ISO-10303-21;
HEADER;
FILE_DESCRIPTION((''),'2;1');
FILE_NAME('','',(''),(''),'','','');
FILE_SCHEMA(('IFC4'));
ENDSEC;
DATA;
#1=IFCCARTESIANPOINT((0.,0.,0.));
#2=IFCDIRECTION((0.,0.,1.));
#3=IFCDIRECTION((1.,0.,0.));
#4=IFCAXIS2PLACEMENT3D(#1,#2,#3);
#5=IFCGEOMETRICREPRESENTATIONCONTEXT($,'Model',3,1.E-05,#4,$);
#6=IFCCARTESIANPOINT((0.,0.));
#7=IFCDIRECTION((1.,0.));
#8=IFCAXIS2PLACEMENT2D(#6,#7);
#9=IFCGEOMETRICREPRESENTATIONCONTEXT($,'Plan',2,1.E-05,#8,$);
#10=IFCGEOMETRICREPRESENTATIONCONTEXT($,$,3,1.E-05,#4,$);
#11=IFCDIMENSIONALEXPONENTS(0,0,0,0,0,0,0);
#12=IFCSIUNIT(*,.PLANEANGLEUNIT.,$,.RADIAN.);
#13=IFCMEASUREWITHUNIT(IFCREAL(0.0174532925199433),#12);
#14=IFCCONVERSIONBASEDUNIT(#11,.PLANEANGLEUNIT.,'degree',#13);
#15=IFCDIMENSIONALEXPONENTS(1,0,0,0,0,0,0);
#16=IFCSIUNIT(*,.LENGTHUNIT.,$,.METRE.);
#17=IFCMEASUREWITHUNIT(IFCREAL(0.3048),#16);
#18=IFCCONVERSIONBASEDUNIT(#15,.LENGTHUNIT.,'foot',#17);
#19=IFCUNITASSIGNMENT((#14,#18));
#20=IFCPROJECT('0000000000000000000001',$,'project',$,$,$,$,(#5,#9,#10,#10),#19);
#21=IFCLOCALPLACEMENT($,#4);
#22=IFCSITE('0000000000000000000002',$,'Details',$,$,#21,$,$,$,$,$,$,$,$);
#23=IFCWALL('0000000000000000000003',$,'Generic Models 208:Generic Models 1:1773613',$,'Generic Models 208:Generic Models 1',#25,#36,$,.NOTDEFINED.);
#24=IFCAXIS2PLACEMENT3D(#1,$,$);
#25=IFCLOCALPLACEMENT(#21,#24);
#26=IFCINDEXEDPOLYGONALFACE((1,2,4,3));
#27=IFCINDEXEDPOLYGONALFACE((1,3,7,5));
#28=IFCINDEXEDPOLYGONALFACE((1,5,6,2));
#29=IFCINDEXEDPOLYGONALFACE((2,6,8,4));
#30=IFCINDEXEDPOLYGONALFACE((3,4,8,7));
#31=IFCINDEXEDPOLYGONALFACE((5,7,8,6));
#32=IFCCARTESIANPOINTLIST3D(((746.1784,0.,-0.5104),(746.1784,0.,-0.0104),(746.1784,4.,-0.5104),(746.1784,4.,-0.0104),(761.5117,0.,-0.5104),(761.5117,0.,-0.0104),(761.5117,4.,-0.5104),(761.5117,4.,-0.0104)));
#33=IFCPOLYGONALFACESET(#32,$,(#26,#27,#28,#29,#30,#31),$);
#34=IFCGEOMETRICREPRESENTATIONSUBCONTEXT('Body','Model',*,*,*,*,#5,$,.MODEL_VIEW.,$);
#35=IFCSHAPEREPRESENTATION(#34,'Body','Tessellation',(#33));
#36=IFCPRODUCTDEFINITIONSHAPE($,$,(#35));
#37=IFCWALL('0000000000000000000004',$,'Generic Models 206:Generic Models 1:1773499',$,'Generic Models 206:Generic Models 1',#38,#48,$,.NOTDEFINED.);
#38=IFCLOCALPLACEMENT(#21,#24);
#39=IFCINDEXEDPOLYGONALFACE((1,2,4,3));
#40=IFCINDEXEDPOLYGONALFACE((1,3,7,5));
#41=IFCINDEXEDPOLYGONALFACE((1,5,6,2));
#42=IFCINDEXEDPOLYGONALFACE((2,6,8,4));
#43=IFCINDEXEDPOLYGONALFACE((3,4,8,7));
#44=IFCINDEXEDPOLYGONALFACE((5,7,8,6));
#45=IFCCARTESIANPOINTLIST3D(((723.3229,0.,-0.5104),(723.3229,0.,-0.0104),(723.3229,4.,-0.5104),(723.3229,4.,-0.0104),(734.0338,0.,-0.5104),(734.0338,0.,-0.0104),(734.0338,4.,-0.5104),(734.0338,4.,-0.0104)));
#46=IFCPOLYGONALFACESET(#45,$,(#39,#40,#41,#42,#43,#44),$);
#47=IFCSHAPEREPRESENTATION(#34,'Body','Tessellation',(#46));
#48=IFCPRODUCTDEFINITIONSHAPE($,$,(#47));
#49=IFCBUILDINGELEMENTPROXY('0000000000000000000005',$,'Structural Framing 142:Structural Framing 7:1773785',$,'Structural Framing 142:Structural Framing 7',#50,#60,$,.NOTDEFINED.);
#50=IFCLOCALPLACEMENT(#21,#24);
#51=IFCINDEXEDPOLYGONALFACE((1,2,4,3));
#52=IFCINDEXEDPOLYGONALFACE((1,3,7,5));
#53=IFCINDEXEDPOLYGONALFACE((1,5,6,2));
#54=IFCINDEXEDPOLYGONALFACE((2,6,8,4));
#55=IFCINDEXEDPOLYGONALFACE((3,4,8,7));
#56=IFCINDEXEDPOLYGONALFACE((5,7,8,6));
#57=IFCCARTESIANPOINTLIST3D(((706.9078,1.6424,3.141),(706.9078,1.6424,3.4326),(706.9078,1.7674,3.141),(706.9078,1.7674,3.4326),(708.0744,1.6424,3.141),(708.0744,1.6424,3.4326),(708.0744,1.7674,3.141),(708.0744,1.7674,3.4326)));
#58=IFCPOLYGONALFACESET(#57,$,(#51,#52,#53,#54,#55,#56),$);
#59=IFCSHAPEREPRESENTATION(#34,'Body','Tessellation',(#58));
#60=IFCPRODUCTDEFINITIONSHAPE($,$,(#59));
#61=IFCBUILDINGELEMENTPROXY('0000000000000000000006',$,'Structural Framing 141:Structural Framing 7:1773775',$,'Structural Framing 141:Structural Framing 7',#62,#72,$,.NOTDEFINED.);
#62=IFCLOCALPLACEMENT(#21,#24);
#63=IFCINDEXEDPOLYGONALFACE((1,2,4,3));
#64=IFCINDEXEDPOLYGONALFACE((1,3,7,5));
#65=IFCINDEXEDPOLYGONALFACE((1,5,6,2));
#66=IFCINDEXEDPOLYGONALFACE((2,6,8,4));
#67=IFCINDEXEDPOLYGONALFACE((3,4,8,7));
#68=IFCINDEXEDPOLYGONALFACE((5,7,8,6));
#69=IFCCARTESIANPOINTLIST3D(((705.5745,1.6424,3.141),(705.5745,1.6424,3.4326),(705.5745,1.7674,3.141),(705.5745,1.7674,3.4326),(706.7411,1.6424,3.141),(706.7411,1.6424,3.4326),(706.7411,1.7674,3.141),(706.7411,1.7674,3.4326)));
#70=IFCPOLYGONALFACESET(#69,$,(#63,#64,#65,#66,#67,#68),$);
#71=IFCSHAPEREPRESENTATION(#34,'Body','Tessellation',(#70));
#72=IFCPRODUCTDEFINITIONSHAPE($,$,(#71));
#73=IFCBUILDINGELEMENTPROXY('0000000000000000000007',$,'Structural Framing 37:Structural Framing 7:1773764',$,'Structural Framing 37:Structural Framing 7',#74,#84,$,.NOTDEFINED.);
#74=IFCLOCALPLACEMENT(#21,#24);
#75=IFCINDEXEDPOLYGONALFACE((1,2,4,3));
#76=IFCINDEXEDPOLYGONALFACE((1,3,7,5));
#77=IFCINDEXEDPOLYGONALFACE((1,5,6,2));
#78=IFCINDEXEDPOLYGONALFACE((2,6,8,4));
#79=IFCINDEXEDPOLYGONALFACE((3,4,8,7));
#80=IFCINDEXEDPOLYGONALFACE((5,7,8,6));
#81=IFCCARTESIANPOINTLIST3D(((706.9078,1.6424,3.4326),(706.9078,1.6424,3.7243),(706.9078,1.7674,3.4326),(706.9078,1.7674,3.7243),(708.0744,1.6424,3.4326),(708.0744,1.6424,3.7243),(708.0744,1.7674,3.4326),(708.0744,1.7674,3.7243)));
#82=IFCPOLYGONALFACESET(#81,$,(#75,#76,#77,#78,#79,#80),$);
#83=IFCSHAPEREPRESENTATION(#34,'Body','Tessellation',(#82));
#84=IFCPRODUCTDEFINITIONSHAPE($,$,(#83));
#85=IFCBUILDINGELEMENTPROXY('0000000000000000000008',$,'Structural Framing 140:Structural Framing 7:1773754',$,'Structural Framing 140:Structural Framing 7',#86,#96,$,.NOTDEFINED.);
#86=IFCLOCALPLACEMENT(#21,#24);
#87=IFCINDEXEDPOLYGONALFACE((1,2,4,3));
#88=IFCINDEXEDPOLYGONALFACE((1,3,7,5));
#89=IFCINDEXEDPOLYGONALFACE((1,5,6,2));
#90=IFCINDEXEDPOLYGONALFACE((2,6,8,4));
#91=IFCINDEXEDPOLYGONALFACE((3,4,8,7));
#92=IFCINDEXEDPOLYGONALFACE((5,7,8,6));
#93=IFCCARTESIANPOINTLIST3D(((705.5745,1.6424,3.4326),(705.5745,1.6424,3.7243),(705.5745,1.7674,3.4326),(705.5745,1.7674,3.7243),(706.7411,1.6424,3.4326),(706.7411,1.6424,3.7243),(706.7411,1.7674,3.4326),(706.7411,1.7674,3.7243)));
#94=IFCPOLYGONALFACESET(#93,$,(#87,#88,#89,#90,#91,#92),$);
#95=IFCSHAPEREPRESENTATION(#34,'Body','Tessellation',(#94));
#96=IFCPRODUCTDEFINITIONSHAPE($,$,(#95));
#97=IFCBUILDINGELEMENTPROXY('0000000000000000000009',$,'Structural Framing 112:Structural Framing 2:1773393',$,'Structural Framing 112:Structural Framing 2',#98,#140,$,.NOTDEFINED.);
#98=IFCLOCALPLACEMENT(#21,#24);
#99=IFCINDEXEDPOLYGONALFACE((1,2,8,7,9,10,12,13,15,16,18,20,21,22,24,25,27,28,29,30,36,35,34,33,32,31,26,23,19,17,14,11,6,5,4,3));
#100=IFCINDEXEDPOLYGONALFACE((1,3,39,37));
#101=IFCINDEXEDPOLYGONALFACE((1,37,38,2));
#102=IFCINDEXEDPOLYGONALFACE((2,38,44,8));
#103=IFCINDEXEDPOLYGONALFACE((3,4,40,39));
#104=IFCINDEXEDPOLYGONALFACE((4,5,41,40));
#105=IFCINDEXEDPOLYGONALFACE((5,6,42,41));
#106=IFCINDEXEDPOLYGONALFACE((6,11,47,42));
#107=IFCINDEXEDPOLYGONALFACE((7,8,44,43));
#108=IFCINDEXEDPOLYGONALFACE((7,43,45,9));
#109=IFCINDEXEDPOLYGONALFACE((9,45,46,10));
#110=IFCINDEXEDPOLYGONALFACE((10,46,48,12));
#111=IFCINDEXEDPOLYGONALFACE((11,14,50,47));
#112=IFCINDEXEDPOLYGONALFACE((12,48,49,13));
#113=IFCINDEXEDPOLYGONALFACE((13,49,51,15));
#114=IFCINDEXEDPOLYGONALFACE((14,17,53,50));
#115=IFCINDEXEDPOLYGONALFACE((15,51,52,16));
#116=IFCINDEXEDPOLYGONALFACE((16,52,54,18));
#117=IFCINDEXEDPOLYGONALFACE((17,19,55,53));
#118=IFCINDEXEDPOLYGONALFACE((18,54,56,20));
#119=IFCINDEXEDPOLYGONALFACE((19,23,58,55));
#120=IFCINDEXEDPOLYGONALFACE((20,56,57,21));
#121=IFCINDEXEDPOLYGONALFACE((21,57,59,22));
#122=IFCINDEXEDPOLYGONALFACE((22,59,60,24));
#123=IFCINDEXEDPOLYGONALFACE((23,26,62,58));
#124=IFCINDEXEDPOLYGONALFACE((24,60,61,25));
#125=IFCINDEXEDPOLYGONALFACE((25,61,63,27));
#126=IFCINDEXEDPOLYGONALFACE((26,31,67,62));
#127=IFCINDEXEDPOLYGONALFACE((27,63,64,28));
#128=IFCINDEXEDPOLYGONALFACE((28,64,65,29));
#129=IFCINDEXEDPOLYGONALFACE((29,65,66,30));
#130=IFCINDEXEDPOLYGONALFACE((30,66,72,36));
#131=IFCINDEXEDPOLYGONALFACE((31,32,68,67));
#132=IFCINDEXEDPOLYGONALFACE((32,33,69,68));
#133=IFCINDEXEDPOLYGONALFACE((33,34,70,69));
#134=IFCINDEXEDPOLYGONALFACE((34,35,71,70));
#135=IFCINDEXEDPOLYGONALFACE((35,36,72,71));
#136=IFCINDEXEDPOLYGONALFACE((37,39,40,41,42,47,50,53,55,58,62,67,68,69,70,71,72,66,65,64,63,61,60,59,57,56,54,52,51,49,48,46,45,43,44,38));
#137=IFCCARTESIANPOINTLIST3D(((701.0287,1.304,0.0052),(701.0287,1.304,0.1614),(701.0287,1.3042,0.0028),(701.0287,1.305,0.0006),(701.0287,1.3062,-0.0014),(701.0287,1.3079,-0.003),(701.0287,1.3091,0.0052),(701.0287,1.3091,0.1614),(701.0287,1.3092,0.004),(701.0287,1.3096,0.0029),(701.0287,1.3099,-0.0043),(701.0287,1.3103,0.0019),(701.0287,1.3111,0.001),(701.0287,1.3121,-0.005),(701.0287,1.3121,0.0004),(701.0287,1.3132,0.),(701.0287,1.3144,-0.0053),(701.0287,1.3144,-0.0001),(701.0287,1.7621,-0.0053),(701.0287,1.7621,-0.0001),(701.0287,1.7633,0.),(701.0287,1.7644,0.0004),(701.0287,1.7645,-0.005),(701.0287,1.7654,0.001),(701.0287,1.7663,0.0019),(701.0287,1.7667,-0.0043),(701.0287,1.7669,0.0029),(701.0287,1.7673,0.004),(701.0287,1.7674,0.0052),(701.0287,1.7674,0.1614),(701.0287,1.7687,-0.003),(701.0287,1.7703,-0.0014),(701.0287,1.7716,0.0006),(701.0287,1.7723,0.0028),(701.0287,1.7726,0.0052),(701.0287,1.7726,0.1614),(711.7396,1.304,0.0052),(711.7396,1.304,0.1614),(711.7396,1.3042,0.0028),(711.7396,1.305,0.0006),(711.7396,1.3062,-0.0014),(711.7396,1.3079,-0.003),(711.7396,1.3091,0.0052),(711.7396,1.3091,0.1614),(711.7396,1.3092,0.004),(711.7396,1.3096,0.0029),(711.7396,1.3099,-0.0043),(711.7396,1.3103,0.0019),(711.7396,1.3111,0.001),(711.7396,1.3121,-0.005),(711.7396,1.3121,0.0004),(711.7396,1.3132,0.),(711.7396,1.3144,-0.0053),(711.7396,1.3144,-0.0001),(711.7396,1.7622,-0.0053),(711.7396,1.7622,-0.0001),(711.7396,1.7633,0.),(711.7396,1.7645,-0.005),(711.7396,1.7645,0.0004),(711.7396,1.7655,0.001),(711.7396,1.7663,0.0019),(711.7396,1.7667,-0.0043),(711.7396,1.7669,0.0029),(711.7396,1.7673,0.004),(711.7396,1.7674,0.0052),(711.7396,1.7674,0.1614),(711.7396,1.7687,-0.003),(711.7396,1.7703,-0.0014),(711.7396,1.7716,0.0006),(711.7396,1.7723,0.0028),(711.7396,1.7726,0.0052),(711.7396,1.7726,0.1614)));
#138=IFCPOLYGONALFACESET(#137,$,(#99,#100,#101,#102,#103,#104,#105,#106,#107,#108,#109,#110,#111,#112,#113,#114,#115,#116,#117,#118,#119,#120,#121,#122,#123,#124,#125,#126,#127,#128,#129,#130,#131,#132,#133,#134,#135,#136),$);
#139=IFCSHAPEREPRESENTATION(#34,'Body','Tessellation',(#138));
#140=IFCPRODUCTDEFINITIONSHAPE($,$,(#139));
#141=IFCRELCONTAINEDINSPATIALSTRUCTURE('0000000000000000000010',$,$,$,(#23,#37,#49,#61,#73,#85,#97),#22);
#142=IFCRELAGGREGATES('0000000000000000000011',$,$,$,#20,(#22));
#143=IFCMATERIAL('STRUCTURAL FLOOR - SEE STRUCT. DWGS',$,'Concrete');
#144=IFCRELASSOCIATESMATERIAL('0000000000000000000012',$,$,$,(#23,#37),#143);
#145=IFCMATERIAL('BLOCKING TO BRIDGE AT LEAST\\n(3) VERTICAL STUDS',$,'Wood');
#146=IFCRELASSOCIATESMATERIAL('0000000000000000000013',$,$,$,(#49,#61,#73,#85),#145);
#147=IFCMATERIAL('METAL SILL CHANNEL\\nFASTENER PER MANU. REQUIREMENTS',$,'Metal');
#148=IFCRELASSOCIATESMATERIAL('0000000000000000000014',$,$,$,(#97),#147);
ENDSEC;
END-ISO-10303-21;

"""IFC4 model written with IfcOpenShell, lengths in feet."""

from ifc_helpers import new_model, entity, si_unit, converted_unit, frame, frame_2d, origin_with_axes, origin_2d_with_axis, place, context, subcontext, project, spatial, polyline, rectangle, outline, extrude, material, element, save


model = new_model("IFC4")

# Units and contexts
model_context = context("Model", 3, precision=1e-05, world=origin_with_axes())
plan_context = context("Plan", 2, precision=1e-05, world=origin_2d_with_axis())
context_of_model = context(None, 3, precision=1e-05, world=origin_with_axes())
body_context = subcontext(model_context, "Body", "Model", "MODEL_VIEW")
ifc_project = project(units=[converted_unit("PLANEANGLEUNIT", "degree", entity("IfcReal", 0.0174532925199433), si_unit("PLANEANGLEUNIT", "RADIAN"), dimensions=[0, 0, 0, 0, 0, 0, 0]), converted_unit("LENGTHUNIT", "foot", entity("IfcReal", 0.3048), si_unit("LENGTHUNIT", "METRE"), dimensions=[1, 0, 0, 0, 0, 0, 0])], contexts=[model_context, plan_context, context_of_model, context_of_model])

# Site
site_placement = place(None, origin_with_axes())
site = spatial("IfcSite", under=ifc_project, at=site_placement, Name="Details")

# Walls
ifc_material_1 = material(Name="STRUCTURAL FLOOR - SEE STRUCT. DWGS", Category="Concrete")
wall_1_placement = place(site_placement, frame((746.1784, 0.0, -0.5104), z_axis=(0.0, 0.0, 1.0), x_axis=(1.0, 0.0, 0.0)))
element("IfcWall", 1, at=wall_1_placement, inside=site, material=ifc_material_1, Name="Generic Models 208:Generic Models 1:1773613", ObjectType="Generic Models 208:Generic Models 1", PredefinedType="NOTDEFINED", context=body_context, shape_type="SweptSolid", body=[
    extrude(rectangle(XDim=4.0, YDim=15.3333, at=frame_2d((0.0, 0.0), x_axis=(1.0, 0.0))), frame((7.6667, 2.0, 0.0), z_axis=(0.0, 0.0, 1.0), x_axis=(0.0, 1.0, 0.0)), (0.0, 0.0, 1.0), 0.5),
])
wall_2_placement = place(site_placement, frame((723.3229, 0.0, -0.5104), z_axis=(0.0, 0.0, 1.0), x_axis=(1.0, 0.0, 0.0)))
element("IfcWall", 2, at=wall_2_placement, inside=site, material=ifc_material_1, Name="Generic Models 206:Generic Models 1:1773499", ObjectType="Generic Models 206:Generic Models 1", PredefinedType="NOTDEFINED", context=body_context, shape_type="SweptSolid", body=[
    extrude(rectangle(XDim=4.0, YDim=10.7109, at=frame_2d((0.0, 0.0), x_axis=(1.0, 0.0))), frame((5.3554, 2.0, 0.0), z_axis=(0.0, 0.0, 1.0), x_axis=(0.0, 1.0, 0.0)), (0.0, 0.0, 1.0), 0.5),
])

# Building element proxies
ifc_material_2 = material(Name="BLOCKING TO BRIDGE AT LEAST\\n(3) VERTICAL STUDS", Category="Wood")
proxy_1_placement = place(site_placement, frame((707.4911, 1.7049, 3.2868), z_axis=(1.0, 0.0, 0.0), x_axis=(0.0, 0.0, -1.0)))
element("IfcBuildingElementProxy", 3, at=proxy_1_placement, inside=site, material=ifc_material_2, Name="Structural Framing 142:Structural Framing 7:1773785", ObjectType="Structural Framing 142:Structural Framing 7", PredefinedType="NOTDEFINED", context=body_context, shape_type="SweptSolid", body=[
    extrude(outline(polyline([(-0.0625, -0.1458), (0.0625, -0.1458), (0.0625, 0.1458), (-0.0625, 0.1458), (-0.0625, -0.1458)])), frame((0.0, 0.0, -0.5833), z_axis=(0.0, 0.0, -1.0), x_axis=(0.0, 1.0, 0.0)), (0.0, 0.0, -1.0), 1.1666),
])
proxy_2_placement = place(site_placement, frame((706.1578, 1.7049, 3.2868), z_axis=(1.0, 0.0, 0.0), x_axis=(0.0, 0.0, -1.0)))
element("IfcBuildingElementProxy", 4, at=proxy_2_placement, inside=site, material=ifc_material_2, Name="Structural Framing 141:Structural Framing 7:1773775", ObjectType="Structural Framing 141:Structural Framing 7", PredefinedType="NOTDEFINED", context=body_context, shape_type="SweptSolid", body=[
    extrude(outline(polyline([(-0.0625, -0.1458), (0.0625, -0.1458), (0.0625, 0.1458), (-0.0625, 0.1458), (-0.0625, -0.1458)])), frame((0.0, 0.0, -0.5833), z_axis=(0.0, 0.0, -1.0), x_axis=(0.0, 1.0, 0.0)), (0.0, 0.0, -1.0), 1.1666),
])
proxy_3_placement = place(site_placement, frame((707.4911, 1.7049, 3.5785), z_axis=(1.0, 0.0, 0.0), x_axis=(0.0, 0.0, -1.0)))
element("IfcBuildingElementProxy", 5, at=proxy_3_placement, inside=site, material=ifc_material_2, Name="Structural Framing 37:Structural Framing 7:1773764", ObjectType="Structural Framing 37:Structural Framing 7", PredefinedType="NOTDEFINED", context=body_context, shape_type="SweptSolid", body=[
    extrude(outline(polyline([(-0.0625, -0.1458), (0.0625, -0.1458), (0.0625, 0.1458), (-0.0625, 0.1458), (-0.0625, -0.1458)])), frame((0.0, 0.0, -0.5833), z_axis=(0.0, 0.0, -1.0), x_axis=(0.0, 1.0, 0.0)), (0.0, 0.0, -1.0), 1.1666),
])
proxy_4_placement = place(site_placement, frame((706.1578, 1.7049, 3.5785), z_axis=(1.0, 0.0, 0.0), x_axis=(0.0, 0.0, -1.0)))
element("IfcBuildingElementProxy", 6, at=proxy_4_placement, inside=site, material=ifc_material_2, Name="Structural Framing 140:Structural Framing 7:1773754", ObjectType="Structural Framing 140:Structural Framing 7", PredefinedType="NOTDEFINED", context=body_context, shape_type="SweptSolid", body=[
    extrude(outline(polyline([(-0.0625, -0.1458), (0.0625, -0.1458), (0.0625, 0.1458), (-0.0625, 0.1458), (-0.0625, -0.1458)])), frame((0.0, 0.0, -0.5833), z_axis=(0.0, 0.0, -1.0), x_axis=(0.0, 1.0, 0.0)), (0.0, 0.0, -1.0), 1.1666),
])
ifc_material_3 = material(Name="METAL SILL CHANNEL\\nFASTENER PER MANU. REQUIREMENTS", Category="Metal")
proxy_5_placement = place(site_placement, frame((706.3842, 1.5383, 0.0316), z_axis=(1.0, 0.0, 0.0), x_axis=(0.0, 0.0, -1.0)))
element("IfcBuildingElementProxy", 7, at=proxy_5_placement, inside=site, material=ifc_material_3, Name="Structural Framing 112:Structural Framing 2:1773393", ObjectType="Structural Framing 112:Structural Framing 2", PredefinedType="NOTDEFINED", context=body_context, shape_type="SweptSolid", body=[
    extrude(outline(polyline([(0.2286, 0.0), (0.2292, -0.001), (0.2295, -0.0022), (0.2295, -0.0034), (0.2183, -0.1592), (0.2235, -0.1596), (0.2347, -0.0037), (0.2346, -0.0014), (0.2339, 0.0009), (0.2328, 0.0029), (0.2313, 0.0047), (0.2294, 0.0061), (0.2273, 0.007), (0.225, 0.0074), (-0.2216, 0.0394), (-0.224, 0.0393), (-0.2262, 0.0387), (-0.2283, 0.0376), (-0.2301, 0.0361), (-0.2314, 0.0342), (-0.2324, 0.0321), (-0.2328, 0.0298), (-0.244, -0.1261), (-0.2388, -0.1264), (-0.2276, 0.0294), (-0.2274, 0.0306), (-0.227, 0.0316), (-0.2263, 0.0326), (-0.2254, 0.0334), (-0.2243, 0.0339), (-0.2232, 0.0342), (-0.222, 0.0343), (0.2246, 0.0023), (0.2258, 0.0021), (0.2269, 0.0016), (0.2278, 0.0009), (0.2286, 0.0)])), frame((0.0134, 0.0, -5.3554), z_axis=(0.000062, 0.0, -1.0), x_axis=(0.07148, 0.997442, 0.000005)), (0.000005, 0.000062, -1.0), 10.7109),
])

save(model, "model.ifc")
